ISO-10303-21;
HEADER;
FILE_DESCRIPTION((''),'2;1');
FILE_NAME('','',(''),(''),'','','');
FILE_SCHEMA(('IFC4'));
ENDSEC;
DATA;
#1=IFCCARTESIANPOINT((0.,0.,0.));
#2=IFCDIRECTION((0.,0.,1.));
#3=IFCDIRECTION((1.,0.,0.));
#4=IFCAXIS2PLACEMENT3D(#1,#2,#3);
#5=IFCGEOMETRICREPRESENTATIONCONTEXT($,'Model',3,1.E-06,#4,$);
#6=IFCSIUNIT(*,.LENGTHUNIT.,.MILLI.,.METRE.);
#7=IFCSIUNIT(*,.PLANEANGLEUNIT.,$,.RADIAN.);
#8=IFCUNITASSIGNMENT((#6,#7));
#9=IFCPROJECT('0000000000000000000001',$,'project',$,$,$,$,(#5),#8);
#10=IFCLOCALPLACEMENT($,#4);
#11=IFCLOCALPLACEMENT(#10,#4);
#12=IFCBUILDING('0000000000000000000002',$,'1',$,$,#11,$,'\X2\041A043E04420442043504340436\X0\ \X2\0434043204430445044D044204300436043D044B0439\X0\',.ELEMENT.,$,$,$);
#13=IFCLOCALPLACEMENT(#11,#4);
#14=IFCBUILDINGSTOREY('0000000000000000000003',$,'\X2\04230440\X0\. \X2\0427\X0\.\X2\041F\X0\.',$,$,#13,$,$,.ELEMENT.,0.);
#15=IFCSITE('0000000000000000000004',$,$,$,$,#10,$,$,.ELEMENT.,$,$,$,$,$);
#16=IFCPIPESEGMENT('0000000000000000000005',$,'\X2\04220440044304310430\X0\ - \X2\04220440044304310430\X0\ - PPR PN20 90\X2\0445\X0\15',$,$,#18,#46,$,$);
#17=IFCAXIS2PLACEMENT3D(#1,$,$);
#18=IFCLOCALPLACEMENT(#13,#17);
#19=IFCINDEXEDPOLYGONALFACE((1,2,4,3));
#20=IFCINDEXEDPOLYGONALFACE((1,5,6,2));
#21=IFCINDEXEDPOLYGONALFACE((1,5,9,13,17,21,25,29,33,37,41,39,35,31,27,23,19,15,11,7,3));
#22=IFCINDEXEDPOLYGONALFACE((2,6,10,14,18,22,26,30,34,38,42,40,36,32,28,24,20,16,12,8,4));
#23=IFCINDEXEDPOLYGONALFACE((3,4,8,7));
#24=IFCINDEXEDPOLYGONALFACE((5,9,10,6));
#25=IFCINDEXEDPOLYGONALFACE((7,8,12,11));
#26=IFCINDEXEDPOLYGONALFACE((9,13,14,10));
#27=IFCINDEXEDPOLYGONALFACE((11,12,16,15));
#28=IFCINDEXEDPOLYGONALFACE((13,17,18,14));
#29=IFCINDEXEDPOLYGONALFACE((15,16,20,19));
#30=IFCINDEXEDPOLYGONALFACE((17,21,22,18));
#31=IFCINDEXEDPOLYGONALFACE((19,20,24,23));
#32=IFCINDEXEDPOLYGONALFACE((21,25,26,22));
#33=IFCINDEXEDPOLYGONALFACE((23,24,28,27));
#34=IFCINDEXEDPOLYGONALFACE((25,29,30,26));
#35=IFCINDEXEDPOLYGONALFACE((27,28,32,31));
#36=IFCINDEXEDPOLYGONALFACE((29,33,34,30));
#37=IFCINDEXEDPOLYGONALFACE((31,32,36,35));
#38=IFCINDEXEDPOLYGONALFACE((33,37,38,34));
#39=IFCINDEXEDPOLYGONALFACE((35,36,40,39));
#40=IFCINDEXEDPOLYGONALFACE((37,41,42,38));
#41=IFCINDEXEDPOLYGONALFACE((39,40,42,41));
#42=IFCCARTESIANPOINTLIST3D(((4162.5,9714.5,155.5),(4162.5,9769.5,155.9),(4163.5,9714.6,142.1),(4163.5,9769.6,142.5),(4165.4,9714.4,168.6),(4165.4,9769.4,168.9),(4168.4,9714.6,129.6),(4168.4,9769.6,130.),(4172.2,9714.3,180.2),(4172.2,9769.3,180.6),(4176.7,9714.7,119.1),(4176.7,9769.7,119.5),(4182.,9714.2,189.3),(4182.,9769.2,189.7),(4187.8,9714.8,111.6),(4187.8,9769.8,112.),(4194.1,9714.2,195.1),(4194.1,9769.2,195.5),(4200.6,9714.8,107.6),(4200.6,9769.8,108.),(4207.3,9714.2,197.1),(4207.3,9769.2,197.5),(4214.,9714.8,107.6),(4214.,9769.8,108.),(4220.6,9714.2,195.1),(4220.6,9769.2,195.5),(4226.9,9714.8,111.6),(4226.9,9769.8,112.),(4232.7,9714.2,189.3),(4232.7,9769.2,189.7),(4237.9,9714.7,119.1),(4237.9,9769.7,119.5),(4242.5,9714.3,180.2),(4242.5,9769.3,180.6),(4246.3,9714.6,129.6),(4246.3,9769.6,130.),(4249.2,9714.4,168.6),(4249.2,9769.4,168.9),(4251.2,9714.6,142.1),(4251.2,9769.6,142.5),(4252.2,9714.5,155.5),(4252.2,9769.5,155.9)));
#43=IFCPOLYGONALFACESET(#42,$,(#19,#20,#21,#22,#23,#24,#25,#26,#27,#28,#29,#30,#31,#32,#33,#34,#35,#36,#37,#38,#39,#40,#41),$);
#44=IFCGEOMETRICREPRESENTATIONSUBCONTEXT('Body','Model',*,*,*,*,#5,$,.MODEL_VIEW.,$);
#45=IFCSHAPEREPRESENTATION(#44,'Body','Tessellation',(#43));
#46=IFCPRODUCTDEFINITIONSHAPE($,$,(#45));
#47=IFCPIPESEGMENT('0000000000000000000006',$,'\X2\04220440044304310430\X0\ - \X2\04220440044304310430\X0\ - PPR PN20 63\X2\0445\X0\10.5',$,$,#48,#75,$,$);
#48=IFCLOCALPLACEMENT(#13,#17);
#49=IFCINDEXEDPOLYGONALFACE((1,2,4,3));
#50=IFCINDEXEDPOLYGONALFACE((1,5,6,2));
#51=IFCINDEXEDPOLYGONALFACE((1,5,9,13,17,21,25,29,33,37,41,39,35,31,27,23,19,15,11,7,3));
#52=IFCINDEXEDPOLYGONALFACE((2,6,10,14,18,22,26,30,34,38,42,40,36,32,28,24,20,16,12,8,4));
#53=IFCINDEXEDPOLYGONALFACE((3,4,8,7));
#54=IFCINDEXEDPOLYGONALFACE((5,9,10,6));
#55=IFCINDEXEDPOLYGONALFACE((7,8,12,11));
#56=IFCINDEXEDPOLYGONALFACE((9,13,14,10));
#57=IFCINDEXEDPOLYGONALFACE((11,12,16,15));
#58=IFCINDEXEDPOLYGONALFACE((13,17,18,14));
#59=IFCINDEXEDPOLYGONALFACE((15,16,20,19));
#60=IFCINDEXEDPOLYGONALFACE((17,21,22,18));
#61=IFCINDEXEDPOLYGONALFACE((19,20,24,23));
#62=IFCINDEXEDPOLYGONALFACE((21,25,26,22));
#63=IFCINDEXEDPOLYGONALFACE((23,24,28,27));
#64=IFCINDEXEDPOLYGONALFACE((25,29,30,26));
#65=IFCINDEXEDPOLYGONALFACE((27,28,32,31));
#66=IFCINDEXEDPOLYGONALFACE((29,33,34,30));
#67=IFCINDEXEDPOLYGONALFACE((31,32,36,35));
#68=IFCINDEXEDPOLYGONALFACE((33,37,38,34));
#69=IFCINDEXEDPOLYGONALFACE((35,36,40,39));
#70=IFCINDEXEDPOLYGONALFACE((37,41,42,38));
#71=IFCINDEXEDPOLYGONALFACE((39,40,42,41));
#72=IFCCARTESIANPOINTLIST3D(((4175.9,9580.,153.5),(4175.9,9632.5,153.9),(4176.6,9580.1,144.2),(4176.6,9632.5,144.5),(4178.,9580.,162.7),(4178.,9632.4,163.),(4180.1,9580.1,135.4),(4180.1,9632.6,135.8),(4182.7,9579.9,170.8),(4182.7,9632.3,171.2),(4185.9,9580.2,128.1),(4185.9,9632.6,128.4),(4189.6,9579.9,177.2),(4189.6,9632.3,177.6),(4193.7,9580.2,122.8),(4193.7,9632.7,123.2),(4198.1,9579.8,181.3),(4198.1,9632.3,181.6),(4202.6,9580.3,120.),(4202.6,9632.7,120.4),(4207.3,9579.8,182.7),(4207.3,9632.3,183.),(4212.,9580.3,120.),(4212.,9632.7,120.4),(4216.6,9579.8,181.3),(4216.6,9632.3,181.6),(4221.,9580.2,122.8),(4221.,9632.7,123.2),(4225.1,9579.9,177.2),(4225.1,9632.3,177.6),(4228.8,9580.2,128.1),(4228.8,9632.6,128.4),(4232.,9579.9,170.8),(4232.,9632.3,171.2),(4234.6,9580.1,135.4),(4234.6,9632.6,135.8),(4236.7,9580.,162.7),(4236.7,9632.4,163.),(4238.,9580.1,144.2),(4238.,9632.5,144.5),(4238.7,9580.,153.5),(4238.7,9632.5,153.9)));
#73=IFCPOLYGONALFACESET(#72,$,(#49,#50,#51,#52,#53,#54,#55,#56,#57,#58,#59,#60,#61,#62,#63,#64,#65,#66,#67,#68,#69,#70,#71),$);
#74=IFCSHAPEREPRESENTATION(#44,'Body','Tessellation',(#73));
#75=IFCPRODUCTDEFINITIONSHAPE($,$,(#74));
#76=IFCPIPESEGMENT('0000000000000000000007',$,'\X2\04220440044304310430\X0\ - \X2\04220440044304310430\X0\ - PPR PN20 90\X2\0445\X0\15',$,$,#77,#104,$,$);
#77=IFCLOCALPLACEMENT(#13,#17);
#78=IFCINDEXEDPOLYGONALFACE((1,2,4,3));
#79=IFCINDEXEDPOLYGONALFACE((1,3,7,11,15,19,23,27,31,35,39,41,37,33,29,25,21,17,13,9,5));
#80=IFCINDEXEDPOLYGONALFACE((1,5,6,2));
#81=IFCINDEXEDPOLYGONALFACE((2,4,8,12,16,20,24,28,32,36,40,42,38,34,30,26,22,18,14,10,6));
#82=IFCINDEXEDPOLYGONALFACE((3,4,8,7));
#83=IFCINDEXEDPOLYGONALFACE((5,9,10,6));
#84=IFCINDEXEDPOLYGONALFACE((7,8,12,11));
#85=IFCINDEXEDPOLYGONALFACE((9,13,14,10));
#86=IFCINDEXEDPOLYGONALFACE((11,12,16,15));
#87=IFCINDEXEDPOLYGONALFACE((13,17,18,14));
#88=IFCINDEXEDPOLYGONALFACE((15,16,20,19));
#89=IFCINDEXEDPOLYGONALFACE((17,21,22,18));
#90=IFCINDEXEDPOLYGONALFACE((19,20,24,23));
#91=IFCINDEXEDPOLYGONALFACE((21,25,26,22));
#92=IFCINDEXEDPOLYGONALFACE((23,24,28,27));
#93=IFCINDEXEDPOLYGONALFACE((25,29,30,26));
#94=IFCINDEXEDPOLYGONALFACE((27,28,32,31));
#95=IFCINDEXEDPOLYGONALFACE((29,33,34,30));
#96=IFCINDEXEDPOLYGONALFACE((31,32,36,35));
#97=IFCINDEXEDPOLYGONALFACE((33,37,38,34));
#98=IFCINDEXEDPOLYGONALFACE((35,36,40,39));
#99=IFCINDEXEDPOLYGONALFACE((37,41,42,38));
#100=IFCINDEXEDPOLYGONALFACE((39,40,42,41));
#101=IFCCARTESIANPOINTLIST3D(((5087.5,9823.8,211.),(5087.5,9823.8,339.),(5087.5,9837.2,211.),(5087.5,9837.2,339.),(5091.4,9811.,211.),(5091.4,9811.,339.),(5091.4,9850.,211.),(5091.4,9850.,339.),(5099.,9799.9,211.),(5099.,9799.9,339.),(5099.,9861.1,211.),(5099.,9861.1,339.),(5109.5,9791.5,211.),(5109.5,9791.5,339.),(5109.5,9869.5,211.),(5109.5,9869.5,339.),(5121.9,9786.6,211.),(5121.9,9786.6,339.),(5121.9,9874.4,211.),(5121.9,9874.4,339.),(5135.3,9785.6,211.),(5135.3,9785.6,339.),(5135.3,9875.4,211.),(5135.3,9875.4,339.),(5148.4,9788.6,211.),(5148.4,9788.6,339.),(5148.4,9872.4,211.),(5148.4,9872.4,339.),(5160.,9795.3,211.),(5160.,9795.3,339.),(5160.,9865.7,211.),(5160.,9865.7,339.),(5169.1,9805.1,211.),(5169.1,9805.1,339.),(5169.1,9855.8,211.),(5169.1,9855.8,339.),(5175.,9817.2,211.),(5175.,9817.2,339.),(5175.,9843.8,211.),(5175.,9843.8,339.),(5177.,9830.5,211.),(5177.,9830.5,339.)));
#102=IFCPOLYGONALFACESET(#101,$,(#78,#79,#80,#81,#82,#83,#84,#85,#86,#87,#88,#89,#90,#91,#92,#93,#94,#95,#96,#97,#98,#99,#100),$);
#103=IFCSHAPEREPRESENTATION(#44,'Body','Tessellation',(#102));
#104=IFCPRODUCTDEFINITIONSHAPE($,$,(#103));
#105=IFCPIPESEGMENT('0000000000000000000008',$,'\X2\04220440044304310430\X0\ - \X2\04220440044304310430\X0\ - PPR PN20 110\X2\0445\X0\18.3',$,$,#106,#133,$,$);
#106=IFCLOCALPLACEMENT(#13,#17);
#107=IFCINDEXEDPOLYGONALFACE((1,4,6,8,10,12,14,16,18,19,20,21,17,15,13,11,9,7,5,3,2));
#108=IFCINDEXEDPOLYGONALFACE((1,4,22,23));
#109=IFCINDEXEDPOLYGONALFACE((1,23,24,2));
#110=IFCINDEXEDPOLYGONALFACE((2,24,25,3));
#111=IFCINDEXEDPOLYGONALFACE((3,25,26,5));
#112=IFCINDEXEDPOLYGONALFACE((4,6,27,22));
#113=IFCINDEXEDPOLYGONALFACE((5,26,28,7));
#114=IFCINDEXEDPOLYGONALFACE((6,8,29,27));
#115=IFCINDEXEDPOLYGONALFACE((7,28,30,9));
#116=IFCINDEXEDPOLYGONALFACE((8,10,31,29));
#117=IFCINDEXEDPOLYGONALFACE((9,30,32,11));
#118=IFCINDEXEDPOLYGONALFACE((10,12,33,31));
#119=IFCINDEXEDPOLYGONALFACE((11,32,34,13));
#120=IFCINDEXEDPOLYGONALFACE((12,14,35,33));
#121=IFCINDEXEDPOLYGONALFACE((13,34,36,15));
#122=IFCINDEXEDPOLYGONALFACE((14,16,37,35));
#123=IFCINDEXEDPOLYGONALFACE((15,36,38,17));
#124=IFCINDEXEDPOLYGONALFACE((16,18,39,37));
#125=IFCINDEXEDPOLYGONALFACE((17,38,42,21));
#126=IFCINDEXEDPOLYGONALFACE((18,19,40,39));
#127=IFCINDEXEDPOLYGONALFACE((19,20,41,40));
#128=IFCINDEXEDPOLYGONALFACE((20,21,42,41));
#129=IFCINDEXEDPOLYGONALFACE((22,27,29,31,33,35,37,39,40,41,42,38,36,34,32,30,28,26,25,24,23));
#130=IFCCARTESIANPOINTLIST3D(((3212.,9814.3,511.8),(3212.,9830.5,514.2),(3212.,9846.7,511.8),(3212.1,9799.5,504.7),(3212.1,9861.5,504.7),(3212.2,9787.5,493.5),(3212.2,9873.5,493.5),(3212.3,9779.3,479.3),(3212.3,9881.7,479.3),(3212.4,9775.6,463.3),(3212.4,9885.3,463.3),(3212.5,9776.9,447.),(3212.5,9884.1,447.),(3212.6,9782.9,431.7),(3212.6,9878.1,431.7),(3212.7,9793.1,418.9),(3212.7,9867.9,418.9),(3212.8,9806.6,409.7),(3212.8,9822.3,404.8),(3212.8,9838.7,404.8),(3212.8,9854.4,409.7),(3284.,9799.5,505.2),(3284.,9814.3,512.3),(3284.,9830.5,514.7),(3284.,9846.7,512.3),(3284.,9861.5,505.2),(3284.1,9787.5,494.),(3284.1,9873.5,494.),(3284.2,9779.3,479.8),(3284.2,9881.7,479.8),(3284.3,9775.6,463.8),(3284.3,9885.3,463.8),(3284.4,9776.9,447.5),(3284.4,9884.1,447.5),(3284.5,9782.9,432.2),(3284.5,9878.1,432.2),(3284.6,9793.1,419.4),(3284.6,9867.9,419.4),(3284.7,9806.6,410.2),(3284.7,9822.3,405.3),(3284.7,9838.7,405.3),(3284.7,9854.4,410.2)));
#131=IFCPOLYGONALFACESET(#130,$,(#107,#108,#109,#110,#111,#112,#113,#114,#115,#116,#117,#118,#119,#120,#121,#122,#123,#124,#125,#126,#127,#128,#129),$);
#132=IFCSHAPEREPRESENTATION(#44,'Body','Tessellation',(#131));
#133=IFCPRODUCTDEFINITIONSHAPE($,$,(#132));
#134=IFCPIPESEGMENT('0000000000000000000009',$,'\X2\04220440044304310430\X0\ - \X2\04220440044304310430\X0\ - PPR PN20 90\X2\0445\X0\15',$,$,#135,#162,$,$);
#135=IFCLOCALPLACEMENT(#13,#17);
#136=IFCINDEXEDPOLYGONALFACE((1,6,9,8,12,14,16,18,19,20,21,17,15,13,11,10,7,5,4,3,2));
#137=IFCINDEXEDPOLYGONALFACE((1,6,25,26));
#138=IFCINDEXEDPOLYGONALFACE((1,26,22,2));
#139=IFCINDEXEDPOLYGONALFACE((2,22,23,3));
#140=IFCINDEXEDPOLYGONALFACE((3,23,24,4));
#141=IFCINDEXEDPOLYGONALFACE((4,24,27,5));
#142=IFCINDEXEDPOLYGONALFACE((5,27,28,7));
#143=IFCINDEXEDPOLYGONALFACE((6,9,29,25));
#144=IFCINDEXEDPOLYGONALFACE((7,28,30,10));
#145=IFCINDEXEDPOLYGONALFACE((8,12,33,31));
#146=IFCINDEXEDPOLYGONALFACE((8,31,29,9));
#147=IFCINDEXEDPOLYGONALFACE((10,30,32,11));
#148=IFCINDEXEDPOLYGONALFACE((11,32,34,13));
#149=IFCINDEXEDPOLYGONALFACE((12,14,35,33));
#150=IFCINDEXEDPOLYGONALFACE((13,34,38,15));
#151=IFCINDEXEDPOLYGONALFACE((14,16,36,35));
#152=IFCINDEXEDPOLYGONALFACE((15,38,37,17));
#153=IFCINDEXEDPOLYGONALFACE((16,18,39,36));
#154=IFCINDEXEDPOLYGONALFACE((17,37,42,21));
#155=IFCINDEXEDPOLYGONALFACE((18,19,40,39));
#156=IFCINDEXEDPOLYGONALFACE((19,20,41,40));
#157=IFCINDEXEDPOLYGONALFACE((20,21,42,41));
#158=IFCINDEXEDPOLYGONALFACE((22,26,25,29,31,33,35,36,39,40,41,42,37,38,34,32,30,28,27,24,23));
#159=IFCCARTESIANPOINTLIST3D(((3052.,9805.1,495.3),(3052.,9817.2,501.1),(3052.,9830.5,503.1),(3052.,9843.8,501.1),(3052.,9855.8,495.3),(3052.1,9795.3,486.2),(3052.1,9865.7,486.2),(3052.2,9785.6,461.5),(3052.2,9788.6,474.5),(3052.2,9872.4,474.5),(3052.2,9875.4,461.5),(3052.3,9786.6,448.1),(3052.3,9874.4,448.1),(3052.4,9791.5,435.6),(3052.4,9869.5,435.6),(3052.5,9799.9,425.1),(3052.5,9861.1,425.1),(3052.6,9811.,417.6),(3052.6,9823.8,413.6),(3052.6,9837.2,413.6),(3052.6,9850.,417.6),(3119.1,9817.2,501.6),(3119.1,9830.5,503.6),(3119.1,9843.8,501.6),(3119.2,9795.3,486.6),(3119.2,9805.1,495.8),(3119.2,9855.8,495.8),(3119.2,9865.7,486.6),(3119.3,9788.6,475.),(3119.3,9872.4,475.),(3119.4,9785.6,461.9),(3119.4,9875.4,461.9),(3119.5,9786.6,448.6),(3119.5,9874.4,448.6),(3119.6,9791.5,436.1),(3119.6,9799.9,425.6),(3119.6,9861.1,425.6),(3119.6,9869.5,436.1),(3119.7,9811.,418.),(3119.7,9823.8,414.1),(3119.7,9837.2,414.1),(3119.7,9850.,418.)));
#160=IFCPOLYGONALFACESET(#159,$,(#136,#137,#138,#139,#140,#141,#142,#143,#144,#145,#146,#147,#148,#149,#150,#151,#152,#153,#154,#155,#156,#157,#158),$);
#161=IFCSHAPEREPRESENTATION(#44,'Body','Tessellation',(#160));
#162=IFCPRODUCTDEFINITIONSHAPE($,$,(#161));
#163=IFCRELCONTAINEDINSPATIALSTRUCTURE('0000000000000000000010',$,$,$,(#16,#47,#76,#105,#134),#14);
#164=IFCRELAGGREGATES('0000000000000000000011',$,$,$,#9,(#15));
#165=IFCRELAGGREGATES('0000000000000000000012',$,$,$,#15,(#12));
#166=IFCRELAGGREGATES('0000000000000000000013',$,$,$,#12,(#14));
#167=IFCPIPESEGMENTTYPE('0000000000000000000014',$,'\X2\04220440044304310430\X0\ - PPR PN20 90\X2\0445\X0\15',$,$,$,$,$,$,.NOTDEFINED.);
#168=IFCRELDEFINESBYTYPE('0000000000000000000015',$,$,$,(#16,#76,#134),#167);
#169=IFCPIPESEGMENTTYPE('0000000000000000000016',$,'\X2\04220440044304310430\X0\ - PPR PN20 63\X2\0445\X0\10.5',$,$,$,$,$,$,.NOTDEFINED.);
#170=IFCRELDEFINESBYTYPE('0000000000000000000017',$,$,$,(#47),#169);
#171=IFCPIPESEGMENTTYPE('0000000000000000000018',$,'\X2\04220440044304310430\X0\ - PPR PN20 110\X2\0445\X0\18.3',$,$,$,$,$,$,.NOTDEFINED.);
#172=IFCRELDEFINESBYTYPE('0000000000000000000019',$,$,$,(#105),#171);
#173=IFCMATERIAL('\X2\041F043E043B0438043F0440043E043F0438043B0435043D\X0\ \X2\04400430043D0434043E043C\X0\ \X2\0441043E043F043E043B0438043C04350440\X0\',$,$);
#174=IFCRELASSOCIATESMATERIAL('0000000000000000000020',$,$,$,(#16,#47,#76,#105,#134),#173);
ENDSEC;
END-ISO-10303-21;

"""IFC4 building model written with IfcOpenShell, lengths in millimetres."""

from ifc_helpers import new_model, entity, si_unit, frame, origin_with_axes, place, context, subcontext, project, spatial, source, transform, mapped, material, type_object, element, save


model = new_model("IFC4")

# Units and contexts
model_context = context("Model", 3, precision=1e-06, world=origin_with_axes())
body_context = subcontext(model_context, "Body", "Model", "MODEL_VIEW")
ifc_project = project(units=[si_unit("LENGTHUNIT", "METRE", prefix="MILLI"), si_unit("PLANEANGLEUNIT", "RADIAN")], contexts=[model_context])

# Site, building, storey
site_placement = place(None, origin_with_axes())
site = spatial("IfcSite", under=ifc_project, at=site_placement, CompositionType="ELEMENT")
building_placement = place(site_placement, origin_with_axes())
building = spatial("IfcBuilding", under=site, at=building_placement, Name="1", LongName="Коттедж двухэтажный", CompositionType="ELEMENT")
storey_placement = place(building_placement, origin_with_axes())
storey = spatial("IfcBuildingStorey", under=building, at=storey_placement, Name="Ур. Ч.П.", CompositionType="ELEMENT", Elevation=0.0)

# Pipe segments
ifc_material_1 = material(Name="Полипропилен рандом сополимер")
pipe_segment_type_1 = type_object("IfcPipeSegmentType", Name="Труба - PPR PN20 110х18.3", PredefinedType="NOTDEFINED")
pipe_segment_type_2 = type_object("IfcPipeSegmentType", Name="Труба - PPR PN20 90х15", PredefinedType="NOTDEFINED")
shared_shape_1 = source(origin_with_axes(), body_context, "Body", "AdvancedSweptSolid", [
    entity("IfcSweptDiskSolid", entity("IfcIndexedPolyCurve", entity("IfcCartesianPointList3D", [[0.0, 0.0, 0.0], [55.0, 0.0, 0.4]]), [entity("IfcLineIndex", [1, 2])]), 45.0),
])
pipe_segment_1_placement = place(storey_placement, frame((4207.3, 9714.5, 152.1), z_axis=(0.0, 0.0, 1.0), x_axis=(0.0, 1.0, 0.0)))
element("IfcPipeSegment", 1, at=pipe_segment_1_placement, inside=storey, type_object=pipe_segment_type_2, material=ifc_material_1, Name="Труба - Труба - PPR PN20 90х15", context=body_context, shape_type="MappedRepresentation", body=[
    mapped(shared_shape_1, transform((0.0, 0.0, 0.0), x_axis=(1.0, 0.0, 0.0), y_axis=(0.0, 1.0, 0.0), z_axis=(0.0, 0.0, 1.0), scale=1.0)),
])
pipe_segment_type_3 = type_object("IfcPipeSegmentType", Name="Труба - PPR PN20 63х10.5", PredefinedType="NOTDEFINED")
shared_shape_2 = source(origin_with_axes(), body_context, "Body", "AdvancedSweptSolid", [
    entity("IfcSweptDiskSolid", entity("IfcIndexedPolyCurve", entity("IfcCartesianPointList3D", [[0.0, 0.0, 0.0], [52.4, 0.0, 0.4]]), [entity("IfcLineIndex", [1, 2])]), 31.5),
])
pipe_segment_2_placement = place(storey_placement, frame((4207.3, 9580.0, 151.2), z_axis=(0.0, 0.0, 1.0), x_axis=(0.0, 1.0, 0.0)))
element("IfcPipeSegment", 2, at=pipe_segment_2_placement, inside=storey, type_object=pipe_segment_type_3, material=ifc_material_1, Name="Труба - Труба - PPR PN20 63х10.5", context=body_context, shape_type="MappedRepresentation", body=[
    mapped(shared_shape_2, transform((0.0, 0.0, 0.0), x_axis=(1.0, 0.0, 0.0), y_axis=(0.0, 1.0, 0.0), z_axis=(0.0, 0.0, 1.0), scale=1.0)),
])
shared_shape_3 = source(origin_with_axes(), body_context, "Body", "AdvancedSweptSolid", [
    entity("IfcSweptDiskSolid", entity("IfcIndexedPolyCurve", entity("IfcCartesianPointList3D", [[0.0, 0.0, 0.0], [0.0, 0.0, 128.0]]), [entity("IfcLineIndex", [1, 2])]), 45.0),
])
pipe_segment_3_placement = place(storey_placement, frame((5132.0, 9830.5, 339.0), z_axis=(0.0, 0.0, -1.0), x_axis=(1.0, 0.0, 0.0)))
element("IfcPipeSegment", 3, at=pipe_segment_3_placement, inside=storey, type_object=pipe_segment_type_2, material=ifc_material_1, Name="Труба - Труба - PPR PN20 90х15", context=body_context, shape_type="MappedRepresentation", body=[
    mapped(shared_shape_3, transform((0.0, 0.0, 0.0), x_axis=(1.0, 0.0, 0.0), y_axis=(0.0, 1.0, 0.0), z_axis=(0.0, 0.0, 1.0), scale=1.0)),
])
shared_shape_4 = source(origin_with_axes(), body_context, "Body", "AdvancedSweptSolid", [
    entity("IfcSweptDiskSolid", entity("IfcIndexedPolyCurve", entity("IfcCartesianPointList3D", [[0.0, 0.0, 0.0], [71.9, 0.0, 0.5]]), [entity("IfcLineIndex", [1, 2])]), 55.0),
])
pipe_segment_4_placement = place(storey_placement, frame((3212.4, 9830.5, 459.2), z_axis=(0.0, 0.0, 1.0), x_axis=(1.0, 0.0, 0.0)))
element("IfcPipeSegment", 4, at=pipe_segment_4_placement, inside=storey, type_object=pipe_segment_type_1, material=ifc_material_1, Name="Труба - Труба - PPR PN20 110х18.3", context=body_context, shape_type="MappedRepresentation", body=[
    mapped(shared_shape_4, transform((0.0, 0.0, 0.0), x_axis=(1.0, 0.0, 0.0), y_axis=(0.0, 1.0, 0.0), z_axis=(0.0, 0.0, 1.0), scale=1.0)),
])
shared_shape_5 = source(origin_with_axes(), body_context, "Body", "AdvancedSweptSolid", [
    entity("IfcSweptDiskSolid", entity("IfcIndexedPolyCurve", entity("IfcCartesianPointList3D", [[0.0, 0.0, 0.0], [67.1, 0.0, 0.5]]), [entity("IfcLineIndex", [1, 2])]), 45.0),
])
pipe_segment_5_placement = place(storey_placement, frame((3052.3, 9830.5, 458.1), z_axis=(0.0, 0.0, 1.0), x_axis=(1.0, 0.0, 0.0)))
element("IfcPipeSegment", 5, at=pipe_segment_5_placement, inside=storey, type_object=pipe_segment_type_2, material=ifc_material_1, Name="Труба - Труба - PPR PN20 90х15", context=body_context, shape_type="MappedRepresentation", body=[
    mapped(shared_shape_5, transform((0.0, 0.0, 0.0), x_axis=(1.0, 0.0, 0.0), y_axis=(0.0, 1.0, 0.0), z_axis=(0.0, 0.0, 1.0), scale=1.0)),
])

save(model, "model.ifc")
